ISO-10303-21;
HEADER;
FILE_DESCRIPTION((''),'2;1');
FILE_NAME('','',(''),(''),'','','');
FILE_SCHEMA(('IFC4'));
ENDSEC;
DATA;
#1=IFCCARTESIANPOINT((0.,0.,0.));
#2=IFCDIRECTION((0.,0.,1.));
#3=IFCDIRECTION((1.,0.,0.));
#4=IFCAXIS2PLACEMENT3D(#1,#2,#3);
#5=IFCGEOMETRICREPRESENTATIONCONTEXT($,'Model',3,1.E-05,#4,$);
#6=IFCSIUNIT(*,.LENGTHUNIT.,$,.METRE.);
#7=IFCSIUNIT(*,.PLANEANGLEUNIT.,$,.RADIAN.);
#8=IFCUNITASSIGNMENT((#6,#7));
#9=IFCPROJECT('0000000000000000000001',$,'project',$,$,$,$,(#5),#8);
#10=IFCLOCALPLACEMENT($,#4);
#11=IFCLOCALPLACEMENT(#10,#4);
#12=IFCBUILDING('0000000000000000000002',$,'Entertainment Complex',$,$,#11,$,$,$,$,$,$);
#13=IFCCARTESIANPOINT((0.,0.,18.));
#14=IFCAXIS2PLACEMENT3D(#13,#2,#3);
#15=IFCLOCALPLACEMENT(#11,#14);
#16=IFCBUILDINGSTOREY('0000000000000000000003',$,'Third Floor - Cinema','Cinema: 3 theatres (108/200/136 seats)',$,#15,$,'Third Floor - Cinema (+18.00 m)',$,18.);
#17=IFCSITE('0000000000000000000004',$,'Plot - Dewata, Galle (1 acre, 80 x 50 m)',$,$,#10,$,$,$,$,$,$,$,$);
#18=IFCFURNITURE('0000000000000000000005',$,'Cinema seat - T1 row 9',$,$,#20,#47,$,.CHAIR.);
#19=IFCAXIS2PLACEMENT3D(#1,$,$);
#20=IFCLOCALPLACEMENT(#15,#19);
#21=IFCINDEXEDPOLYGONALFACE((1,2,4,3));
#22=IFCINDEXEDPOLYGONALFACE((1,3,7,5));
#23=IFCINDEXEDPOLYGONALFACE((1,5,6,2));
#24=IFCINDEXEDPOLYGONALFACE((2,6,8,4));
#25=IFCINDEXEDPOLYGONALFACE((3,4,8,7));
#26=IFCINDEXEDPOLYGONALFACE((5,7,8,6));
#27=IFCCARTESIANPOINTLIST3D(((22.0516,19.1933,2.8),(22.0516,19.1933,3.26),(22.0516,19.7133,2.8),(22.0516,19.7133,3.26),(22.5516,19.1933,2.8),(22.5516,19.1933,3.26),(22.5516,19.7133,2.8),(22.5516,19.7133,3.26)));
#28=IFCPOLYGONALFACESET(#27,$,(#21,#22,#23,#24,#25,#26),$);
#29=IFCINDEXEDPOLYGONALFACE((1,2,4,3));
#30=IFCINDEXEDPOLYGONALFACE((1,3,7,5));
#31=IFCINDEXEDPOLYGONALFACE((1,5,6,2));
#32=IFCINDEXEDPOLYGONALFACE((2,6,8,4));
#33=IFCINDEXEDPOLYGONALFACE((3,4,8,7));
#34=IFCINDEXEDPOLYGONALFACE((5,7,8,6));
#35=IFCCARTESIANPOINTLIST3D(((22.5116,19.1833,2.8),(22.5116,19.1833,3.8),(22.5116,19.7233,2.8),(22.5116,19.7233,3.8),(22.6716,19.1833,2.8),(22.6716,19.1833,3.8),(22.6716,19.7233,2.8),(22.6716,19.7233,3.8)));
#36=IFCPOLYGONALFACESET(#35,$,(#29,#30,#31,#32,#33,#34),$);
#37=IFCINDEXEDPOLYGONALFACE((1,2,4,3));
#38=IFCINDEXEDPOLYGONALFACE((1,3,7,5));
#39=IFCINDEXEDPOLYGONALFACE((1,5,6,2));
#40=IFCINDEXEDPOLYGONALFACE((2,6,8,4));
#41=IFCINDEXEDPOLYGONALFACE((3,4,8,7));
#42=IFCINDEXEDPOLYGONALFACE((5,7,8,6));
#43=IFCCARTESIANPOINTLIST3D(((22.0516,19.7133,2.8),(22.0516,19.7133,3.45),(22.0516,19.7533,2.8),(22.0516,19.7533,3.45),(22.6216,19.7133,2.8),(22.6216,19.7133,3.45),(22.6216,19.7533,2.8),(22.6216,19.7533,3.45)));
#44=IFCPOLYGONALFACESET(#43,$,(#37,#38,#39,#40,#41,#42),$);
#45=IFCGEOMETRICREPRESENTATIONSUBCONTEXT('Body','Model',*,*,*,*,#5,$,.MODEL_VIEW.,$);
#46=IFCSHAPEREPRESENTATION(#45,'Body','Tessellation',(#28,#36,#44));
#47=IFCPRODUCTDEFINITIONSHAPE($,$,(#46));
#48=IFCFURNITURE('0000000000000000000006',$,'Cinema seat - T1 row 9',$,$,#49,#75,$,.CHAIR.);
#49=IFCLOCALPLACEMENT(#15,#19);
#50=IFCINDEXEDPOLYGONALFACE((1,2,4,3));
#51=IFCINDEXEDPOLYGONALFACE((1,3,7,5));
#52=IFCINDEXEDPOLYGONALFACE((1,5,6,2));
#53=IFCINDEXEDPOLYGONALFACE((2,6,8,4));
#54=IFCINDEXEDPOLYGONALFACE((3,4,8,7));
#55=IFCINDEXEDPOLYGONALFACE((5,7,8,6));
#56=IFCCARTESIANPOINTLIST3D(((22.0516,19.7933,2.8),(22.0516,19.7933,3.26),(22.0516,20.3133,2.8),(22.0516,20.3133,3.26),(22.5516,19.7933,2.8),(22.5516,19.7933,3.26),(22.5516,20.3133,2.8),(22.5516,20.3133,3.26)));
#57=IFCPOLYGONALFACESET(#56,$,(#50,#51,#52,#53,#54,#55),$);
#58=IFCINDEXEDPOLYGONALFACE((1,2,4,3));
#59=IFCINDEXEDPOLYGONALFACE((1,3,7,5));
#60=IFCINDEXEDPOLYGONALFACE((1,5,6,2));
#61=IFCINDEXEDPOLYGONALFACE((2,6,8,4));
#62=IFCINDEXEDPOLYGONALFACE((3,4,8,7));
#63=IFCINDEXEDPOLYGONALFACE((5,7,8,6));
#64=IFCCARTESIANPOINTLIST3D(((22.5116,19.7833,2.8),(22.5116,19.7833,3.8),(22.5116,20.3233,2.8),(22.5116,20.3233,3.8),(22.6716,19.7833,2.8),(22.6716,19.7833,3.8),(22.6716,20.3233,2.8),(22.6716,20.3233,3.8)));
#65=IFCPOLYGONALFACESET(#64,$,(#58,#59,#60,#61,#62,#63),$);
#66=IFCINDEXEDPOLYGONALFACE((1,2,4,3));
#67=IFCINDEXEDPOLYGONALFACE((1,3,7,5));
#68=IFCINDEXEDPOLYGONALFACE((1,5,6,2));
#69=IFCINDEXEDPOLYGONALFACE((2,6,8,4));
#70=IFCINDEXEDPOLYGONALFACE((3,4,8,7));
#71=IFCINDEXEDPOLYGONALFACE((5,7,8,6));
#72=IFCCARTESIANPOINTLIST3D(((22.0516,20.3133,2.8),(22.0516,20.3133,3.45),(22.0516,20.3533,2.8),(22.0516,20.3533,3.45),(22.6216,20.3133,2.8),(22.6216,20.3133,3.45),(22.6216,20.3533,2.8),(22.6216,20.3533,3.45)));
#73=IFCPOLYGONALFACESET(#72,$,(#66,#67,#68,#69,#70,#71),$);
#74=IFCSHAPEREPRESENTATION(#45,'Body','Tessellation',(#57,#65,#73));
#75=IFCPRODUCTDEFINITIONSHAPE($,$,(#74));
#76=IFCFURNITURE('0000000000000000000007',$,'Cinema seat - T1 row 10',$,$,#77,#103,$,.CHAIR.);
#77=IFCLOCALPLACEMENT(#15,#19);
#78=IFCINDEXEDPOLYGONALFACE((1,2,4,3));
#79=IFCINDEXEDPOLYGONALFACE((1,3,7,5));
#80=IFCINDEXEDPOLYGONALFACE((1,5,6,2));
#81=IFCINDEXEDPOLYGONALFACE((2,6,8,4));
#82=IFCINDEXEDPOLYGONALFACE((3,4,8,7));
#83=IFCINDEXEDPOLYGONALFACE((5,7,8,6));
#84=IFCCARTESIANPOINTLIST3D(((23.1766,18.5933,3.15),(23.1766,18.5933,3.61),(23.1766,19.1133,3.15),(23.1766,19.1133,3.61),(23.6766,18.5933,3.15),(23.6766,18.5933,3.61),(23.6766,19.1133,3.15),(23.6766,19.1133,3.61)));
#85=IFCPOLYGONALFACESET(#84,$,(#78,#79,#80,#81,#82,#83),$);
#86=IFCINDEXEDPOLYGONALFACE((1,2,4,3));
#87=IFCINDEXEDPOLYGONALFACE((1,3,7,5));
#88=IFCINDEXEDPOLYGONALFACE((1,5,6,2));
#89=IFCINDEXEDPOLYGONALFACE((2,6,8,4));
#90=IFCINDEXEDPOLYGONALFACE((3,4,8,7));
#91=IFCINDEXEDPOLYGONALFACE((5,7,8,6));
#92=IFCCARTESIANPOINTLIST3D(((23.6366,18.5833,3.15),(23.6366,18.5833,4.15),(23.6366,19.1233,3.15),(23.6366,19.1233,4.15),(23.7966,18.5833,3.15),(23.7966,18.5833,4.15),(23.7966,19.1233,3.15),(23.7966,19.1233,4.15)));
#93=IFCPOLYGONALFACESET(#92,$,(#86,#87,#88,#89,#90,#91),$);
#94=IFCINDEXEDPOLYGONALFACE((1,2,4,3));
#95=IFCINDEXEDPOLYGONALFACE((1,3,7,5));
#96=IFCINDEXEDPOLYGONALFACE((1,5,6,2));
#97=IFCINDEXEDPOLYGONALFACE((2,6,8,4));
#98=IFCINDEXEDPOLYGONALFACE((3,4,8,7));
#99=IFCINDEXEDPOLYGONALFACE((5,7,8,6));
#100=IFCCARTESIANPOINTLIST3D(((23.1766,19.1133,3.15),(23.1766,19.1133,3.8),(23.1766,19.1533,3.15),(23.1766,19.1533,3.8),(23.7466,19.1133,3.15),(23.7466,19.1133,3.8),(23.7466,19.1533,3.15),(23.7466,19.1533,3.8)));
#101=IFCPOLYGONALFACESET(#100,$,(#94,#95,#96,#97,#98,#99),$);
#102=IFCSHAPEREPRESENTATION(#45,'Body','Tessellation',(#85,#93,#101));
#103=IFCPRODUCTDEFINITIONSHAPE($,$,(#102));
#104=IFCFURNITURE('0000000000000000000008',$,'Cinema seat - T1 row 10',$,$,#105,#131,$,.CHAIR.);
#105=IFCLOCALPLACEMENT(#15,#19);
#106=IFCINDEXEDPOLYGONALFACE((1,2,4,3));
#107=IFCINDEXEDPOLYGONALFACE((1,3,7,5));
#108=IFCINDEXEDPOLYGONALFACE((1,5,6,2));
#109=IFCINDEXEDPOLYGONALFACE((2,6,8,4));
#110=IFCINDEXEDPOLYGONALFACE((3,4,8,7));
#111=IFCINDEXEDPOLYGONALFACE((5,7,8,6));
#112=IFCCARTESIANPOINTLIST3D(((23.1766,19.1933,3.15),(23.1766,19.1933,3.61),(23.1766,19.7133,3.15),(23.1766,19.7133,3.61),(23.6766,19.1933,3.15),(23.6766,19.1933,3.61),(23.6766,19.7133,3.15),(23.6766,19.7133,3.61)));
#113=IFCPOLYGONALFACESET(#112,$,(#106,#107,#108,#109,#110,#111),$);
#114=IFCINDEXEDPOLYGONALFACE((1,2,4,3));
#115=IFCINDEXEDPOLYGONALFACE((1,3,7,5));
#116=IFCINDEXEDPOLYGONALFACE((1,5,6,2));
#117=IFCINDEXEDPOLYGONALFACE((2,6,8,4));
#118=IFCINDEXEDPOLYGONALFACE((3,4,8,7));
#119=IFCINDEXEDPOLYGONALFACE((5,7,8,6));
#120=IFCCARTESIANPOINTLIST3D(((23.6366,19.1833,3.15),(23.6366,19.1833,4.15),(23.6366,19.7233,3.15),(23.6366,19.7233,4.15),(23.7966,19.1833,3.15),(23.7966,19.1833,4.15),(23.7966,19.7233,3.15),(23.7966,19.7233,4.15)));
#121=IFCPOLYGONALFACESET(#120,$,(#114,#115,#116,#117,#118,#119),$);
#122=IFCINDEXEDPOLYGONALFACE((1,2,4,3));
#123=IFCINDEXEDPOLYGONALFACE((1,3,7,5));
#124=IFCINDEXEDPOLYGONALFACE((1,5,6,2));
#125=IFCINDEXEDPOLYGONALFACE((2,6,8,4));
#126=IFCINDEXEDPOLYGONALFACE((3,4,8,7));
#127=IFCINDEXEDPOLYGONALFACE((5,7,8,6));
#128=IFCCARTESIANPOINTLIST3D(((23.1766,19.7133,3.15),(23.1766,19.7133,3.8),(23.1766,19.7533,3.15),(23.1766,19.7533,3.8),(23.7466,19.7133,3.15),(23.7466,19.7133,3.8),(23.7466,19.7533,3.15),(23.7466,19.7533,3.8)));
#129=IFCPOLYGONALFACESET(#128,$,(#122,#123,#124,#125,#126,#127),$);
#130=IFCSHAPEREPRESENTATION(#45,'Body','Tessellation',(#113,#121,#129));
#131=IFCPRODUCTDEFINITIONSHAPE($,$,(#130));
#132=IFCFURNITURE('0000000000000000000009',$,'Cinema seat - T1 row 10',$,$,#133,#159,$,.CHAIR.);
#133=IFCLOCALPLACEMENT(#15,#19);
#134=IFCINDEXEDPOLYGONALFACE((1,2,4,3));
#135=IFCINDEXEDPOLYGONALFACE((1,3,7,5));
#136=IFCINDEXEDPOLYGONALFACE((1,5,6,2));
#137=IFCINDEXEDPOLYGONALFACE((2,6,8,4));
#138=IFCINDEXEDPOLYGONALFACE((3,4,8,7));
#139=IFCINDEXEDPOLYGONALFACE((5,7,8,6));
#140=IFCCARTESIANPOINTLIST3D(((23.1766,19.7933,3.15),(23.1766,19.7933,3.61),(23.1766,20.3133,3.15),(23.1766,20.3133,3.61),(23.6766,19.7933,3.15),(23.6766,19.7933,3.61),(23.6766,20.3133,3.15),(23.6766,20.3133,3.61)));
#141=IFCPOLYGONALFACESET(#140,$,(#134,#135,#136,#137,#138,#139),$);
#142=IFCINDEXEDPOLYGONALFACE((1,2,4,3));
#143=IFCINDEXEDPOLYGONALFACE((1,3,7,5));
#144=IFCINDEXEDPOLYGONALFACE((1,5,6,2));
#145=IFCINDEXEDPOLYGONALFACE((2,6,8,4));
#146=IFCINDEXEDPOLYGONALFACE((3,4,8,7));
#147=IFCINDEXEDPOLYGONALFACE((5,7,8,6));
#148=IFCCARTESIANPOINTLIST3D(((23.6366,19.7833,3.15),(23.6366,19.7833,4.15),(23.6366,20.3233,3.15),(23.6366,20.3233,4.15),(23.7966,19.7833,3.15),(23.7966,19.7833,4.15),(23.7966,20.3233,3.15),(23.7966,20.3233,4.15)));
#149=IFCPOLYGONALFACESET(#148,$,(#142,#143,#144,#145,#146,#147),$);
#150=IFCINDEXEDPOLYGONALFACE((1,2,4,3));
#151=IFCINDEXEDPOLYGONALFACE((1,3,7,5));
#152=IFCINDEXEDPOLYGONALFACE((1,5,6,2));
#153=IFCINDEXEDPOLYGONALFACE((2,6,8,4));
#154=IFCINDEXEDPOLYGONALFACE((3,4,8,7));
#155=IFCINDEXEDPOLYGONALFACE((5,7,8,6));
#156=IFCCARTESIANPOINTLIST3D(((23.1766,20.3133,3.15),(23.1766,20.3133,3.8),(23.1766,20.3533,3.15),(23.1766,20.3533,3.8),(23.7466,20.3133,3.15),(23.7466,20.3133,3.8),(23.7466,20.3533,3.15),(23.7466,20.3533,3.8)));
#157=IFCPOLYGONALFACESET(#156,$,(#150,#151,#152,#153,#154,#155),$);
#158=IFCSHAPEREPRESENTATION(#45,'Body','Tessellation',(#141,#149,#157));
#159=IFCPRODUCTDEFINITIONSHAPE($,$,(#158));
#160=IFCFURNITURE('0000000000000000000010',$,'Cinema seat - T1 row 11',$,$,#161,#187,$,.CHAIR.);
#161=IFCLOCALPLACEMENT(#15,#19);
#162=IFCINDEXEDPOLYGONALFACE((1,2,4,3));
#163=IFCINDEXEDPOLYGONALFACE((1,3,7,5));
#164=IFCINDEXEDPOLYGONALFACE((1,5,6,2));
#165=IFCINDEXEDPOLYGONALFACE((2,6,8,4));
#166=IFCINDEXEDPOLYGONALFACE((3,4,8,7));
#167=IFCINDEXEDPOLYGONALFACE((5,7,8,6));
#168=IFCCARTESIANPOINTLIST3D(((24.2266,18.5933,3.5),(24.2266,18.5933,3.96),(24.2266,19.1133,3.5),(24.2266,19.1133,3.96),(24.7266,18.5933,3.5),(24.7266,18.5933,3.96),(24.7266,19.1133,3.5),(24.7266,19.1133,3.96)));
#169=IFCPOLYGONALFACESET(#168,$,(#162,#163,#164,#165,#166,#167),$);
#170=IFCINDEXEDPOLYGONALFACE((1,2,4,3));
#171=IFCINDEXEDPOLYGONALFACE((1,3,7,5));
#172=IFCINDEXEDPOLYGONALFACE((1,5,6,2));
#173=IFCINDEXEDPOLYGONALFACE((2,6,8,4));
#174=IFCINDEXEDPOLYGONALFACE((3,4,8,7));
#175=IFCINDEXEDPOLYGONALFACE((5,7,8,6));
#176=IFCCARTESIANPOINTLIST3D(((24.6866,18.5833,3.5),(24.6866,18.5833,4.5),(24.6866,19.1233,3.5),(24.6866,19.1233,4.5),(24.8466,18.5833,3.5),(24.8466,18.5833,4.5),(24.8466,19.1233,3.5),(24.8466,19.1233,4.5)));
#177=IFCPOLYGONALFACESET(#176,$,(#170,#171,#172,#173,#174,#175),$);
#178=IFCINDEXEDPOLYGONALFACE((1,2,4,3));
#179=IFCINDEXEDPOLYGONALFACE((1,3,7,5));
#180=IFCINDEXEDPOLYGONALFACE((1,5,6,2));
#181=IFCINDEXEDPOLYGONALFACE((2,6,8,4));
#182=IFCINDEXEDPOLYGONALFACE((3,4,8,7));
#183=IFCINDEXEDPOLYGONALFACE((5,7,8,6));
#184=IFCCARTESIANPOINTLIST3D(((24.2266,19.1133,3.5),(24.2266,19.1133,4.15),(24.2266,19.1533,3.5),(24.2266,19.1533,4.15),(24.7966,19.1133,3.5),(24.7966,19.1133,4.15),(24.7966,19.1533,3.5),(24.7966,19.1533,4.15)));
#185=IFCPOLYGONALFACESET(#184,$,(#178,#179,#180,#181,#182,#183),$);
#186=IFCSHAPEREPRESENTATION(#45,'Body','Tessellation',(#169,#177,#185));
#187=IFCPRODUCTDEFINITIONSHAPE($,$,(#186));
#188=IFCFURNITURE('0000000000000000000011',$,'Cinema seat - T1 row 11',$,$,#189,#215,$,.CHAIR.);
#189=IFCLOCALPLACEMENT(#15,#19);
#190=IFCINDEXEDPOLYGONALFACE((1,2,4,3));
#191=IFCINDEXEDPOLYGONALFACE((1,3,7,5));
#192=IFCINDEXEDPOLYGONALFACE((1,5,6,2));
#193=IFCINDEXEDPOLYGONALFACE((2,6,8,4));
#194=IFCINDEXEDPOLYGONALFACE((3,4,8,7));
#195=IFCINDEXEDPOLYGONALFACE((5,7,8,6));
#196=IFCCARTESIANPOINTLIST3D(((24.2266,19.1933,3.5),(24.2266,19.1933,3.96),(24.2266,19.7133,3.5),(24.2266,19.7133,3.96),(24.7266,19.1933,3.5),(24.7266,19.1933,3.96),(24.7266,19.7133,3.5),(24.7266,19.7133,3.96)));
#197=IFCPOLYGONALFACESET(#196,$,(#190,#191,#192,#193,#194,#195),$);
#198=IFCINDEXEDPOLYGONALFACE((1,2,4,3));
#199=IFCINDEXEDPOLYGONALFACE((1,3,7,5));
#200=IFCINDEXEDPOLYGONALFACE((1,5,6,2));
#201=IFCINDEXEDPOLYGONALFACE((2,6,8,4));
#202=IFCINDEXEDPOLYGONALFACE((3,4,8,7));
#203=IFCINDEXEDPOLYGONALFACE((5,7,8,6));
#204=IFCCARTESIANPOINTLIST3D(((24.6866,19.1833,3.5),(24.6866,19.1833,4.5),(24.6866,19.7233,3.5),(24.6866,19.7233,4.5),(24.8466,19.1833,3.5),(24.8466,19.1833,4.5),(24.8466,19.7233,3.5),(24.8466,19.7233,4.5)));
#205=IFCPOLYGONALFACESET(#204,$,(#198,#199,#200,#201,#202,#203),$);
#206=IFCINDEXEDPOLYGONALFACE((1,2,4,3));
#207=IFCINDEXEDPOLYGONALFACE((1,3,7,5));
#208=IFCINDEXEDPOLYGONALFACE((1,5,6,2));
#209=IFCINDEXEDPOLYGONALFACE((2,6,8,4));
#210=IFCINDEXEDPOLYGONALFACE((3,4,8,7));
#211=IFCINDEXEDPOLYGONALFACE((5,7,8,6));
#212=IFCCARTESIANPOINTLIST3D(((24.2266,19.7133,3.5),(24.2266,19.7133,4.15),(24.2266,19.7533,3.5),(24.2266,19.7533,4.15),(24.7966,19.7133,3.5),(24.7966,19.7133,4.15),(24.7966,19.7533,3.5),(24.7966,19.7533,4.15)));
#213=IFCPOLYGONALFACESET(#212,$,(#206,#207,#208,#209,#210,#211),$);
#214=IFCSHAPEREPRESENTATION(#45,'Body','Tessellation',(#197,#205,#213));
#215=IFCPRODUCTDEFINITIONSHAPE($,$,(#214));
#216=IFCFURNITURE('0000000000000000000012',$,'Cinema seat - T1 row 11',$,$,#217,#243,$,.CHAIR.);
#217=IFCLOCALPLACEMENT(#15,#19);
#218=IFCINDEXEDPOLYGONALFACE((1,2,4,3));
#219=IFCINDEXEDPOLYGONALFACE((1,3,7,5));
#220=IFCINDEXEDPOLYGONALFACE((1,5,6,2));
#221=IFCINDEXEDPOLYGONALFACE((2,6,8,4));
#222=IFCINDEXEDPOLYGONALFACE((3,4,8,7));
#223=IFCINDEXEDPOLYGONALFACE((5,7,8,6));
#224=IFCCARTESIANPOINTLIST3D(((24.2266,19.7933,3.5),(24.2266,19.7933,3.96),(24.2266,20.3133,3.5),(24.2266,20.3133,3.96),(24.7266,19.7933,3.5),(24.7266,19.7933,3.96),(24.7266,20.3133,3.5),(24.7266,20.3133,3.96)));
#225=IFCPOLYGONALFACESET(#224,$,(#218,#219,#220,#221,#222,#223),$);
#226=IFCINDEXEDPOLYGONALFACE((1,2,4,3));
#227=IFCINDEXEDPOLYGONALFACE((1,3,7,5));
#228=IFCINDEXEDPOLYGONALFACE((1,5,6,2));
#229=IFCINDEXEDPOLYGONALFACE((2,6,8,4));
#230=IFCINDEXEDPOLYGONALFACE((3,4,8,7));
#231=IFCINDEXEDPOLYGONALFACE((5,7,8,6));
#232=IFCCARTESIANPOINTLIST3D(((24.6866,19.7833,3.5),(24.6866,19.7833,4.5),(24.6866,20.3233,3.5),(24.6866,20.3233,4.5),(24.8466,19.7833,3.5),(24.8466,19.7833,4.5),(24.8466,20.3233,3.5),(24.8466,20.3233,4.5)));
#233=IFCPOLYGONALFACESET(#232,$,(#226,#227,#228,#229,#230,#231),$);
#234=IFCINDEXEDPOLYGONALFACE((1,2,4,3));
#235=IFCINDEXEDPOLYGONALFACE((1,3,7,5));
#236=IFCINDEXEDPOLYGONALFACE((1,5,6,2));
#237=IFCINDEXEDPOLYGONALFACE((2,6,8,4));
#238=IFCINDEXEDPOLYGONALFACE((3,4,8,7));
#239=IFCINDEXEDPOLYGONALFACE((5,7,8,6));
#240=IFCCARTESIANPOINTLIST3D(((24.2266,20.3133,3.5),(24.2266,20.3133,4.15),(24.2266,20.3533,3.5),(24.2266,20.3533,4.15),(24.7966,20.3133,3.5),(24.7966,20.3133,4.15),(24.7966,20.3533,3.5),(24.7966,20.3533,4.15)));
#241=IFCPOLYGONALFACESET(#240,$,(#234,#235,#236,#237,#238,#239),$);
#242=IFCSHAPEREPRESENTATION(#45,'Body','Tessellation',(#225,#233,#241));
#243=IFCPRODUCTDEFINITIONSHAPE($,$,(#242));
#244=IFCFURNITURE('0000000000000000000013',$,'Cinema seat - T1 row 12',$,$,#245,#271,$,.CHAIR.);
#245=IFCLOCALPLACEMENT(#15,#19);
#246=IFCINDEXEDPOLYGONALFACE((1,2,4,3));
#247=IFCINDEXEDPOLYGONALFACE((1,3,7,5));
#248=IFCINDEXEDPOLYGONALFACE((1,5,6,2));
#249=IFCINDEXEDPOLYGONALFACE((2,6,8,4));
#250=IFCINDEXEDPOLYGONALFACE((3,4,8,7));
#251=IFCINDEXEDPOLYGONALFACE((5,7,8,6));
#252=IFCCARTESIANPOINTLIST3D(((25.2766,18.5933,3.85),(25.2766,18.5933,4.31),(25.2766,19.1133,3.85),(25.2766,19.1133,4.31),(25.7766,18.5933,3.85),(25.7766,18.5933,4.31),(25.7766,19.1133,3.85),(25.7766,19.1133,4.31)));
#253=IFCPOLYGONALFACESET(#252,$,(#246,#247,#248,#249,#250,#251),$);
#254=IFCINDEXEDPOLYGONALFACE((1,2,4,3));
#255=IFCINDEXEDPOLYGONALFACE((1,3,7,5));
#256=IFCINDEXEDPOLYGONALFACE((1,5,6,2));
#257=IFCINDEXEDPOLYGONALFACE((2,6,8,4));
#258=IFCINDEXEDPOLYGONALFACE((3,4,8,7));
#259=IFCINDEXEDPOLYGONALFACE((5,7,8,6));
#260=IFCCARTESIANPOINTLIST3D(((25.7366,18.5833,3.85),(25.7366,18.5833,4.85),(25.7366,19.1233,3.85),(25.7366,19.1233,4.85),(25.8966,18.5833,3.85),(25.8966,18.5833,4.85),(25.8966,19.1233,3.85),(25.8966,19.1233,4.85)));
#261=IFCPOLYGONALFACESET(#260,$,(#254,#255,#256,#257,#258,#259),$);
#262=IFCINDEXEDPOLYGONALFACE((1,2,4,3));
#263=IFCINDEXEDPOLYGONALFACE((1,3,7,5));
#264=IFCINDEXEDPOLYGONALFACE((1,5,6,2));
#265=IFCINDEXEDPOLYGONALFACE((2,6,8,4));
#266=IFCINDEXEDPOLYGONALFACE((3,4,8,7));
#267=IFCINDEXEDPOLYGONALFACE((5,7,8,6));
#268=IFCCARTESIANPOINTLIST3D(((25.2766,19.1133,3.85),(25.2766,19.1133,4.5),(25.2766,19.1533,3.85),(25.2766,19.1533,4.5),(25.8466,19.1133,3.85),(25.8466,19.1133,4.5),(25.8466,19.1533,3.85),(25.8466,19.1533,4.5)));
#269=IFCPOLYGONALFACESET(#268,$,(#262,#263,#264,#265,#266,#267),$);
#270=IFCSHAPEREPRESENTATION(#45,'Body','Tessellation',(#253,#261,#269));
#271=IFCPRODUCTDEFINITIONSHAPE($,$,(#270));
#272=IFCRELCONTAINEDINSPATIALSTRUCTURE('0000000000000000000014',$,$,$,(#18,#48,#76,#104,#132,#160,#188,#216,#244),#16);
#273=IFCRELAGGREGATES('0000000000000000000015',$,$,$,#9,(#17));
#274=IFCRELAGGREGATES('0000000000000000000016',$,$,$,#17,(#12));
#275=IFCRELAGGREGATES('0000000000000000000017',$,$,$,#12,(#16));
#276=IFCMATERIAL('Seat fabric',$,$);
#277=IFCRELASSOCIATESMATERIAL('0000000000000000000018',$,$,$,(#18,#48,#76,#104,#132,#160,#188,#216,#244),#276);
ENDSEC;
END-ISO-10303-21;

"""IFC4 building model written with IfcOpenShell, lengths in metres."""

from ifc_helpers import new_model, si_unit, frame, origin_with_axes, place, context, subcontext, project, spatial, polyline, outline, extrude, material, element, save


model = new_model("IFC4")

# Units and contexts
model_context = context("Model", 3, precision=1e-05, world=origin_with_axes())
body_context = subcontext(model_context, "Body", "Model", "MODEL_VIEW")
ifc_project = project(units=[si_unit("LENGTHUNIT", "METRE"), si_unit("PLANEANGLEUNIT", "RADIAN")], contexts=[model_context])

# Site, building, storey
site_placement = place(None, origin_with_axes())
site = spatial("IfcSite", under=ifc_project, at=site_placement, Name="Plot - Dewata, Galle (1 acre, 80 x 50 m)")
building_placement = place(site_placement, origin_with_axes())
building = spatial("IfcBuilding", under=site, at=building_placement, Name="Entertainment Complex")
storey_placement = place(building_placement, frame((0.0, 0.0, 18.0), z_axis=(0.0, 0.0, 1.0), x_axis=(1.0, 0.0, 0.0)))
storey = spatial("IfcBuildingStorey", under=building, at=storey_placement, Name="Third Floor - Cinema", Description="Cinema: 3 theatres (108/200/136 seats)", LongName="Third Floor - Cinema (+18.00 m)", Elevation=18.0)

# Furniture
ifc_material_1 = material(Name="Seat fabric")
for number, where, z_axis, x_axis, name in (
    (1, (22.6716, 19.4533, 2.8), (0.0, 0.0, 1.0), (1.0, 0.0, 0.0), "Cinema seat - T1 row 9"),
    (2, (22.6716, 20.0533, 2.8), (0.0, 0.0, 1.0), (1.0, 0.0, 0.0), "Cinema seat - T1 row 9"),
    (3, (23.7966, 18.8533, 3.15), (0.0, 0.0, 1.0), (1.0, 0.0, 0.0), "Cinema seat - T1 row 10"),
    (4, (23.7966, 19.4533, 3.15), (0.0, 0.0, 1.0), (1.0, 0.0, 0.0), "Cinema seat - T1 row 10"),
    (5, (23.7966, 20.0533, 3.15), (0.0, 0.0, 1.0), (1.0, 0.0, 0.0), "Cinema seat - T1 row 10"),
    (6, (24.8466, 18.8533, 3.5), (0.0, 0.0, 1.0), (1.0, 0.0, 0.0), "Cinema seat - T1 row 11"),
    (7, (24.8466, 19.4533, 3.5), (0.0, 0.0, 1.0), (1.0, 0.0, 0.0), "Cinema seat - T1 row 11"),
    (8, (24.8466, 20.0533, 3.5), (0.0, 0.0, 1.0), (1.0, 0.0, 0.0), "Cinema seat - T1 row 11"),
    (9, (25.8966, 18.8533, 3.85), (0.0, 0.0, 1.0), (1.0, 0.0, 0.0), "Cinema seat - T1 row 12"),
):
    element("IfcFurniture", number, at=place(storey_placement, frame(where, z_axis=z_axis, x_axis=x_axis)), inside=storey, material=ifc_material_1, Name=name, PredefinedType="CHAIR", context=body_context, shape_type="SweptSolid", body=[
        extrude(outline(polyline([(-0.62, -0.26), (-0.12, -0.26), (-0.12, 0.26), (-0.62, 0.26), (-0.62, -0.26)])), origin_with_axes(), (0.0, 0.0, 1.0), 0.46),
        extrude(outline(polyline([(-0.16, -0.27), (0.0, -0.27), (0.0, 0.27), (-0.16, 0.27), (-0.16, -0.27)])), origin_with_axes(), (0.0, 0.0, 1.0), 1.0),
        extrude(outline(polyline([(-0.62, 0.26), (-0.05, 0.26), (-0.05, 0.3), (-0.62, 0.3), (-0.62, 0.26)])), origin_with_axes(), (0.0, 0.0, 1.0), 0.65),
    ])

save(model, "model.ifc")
